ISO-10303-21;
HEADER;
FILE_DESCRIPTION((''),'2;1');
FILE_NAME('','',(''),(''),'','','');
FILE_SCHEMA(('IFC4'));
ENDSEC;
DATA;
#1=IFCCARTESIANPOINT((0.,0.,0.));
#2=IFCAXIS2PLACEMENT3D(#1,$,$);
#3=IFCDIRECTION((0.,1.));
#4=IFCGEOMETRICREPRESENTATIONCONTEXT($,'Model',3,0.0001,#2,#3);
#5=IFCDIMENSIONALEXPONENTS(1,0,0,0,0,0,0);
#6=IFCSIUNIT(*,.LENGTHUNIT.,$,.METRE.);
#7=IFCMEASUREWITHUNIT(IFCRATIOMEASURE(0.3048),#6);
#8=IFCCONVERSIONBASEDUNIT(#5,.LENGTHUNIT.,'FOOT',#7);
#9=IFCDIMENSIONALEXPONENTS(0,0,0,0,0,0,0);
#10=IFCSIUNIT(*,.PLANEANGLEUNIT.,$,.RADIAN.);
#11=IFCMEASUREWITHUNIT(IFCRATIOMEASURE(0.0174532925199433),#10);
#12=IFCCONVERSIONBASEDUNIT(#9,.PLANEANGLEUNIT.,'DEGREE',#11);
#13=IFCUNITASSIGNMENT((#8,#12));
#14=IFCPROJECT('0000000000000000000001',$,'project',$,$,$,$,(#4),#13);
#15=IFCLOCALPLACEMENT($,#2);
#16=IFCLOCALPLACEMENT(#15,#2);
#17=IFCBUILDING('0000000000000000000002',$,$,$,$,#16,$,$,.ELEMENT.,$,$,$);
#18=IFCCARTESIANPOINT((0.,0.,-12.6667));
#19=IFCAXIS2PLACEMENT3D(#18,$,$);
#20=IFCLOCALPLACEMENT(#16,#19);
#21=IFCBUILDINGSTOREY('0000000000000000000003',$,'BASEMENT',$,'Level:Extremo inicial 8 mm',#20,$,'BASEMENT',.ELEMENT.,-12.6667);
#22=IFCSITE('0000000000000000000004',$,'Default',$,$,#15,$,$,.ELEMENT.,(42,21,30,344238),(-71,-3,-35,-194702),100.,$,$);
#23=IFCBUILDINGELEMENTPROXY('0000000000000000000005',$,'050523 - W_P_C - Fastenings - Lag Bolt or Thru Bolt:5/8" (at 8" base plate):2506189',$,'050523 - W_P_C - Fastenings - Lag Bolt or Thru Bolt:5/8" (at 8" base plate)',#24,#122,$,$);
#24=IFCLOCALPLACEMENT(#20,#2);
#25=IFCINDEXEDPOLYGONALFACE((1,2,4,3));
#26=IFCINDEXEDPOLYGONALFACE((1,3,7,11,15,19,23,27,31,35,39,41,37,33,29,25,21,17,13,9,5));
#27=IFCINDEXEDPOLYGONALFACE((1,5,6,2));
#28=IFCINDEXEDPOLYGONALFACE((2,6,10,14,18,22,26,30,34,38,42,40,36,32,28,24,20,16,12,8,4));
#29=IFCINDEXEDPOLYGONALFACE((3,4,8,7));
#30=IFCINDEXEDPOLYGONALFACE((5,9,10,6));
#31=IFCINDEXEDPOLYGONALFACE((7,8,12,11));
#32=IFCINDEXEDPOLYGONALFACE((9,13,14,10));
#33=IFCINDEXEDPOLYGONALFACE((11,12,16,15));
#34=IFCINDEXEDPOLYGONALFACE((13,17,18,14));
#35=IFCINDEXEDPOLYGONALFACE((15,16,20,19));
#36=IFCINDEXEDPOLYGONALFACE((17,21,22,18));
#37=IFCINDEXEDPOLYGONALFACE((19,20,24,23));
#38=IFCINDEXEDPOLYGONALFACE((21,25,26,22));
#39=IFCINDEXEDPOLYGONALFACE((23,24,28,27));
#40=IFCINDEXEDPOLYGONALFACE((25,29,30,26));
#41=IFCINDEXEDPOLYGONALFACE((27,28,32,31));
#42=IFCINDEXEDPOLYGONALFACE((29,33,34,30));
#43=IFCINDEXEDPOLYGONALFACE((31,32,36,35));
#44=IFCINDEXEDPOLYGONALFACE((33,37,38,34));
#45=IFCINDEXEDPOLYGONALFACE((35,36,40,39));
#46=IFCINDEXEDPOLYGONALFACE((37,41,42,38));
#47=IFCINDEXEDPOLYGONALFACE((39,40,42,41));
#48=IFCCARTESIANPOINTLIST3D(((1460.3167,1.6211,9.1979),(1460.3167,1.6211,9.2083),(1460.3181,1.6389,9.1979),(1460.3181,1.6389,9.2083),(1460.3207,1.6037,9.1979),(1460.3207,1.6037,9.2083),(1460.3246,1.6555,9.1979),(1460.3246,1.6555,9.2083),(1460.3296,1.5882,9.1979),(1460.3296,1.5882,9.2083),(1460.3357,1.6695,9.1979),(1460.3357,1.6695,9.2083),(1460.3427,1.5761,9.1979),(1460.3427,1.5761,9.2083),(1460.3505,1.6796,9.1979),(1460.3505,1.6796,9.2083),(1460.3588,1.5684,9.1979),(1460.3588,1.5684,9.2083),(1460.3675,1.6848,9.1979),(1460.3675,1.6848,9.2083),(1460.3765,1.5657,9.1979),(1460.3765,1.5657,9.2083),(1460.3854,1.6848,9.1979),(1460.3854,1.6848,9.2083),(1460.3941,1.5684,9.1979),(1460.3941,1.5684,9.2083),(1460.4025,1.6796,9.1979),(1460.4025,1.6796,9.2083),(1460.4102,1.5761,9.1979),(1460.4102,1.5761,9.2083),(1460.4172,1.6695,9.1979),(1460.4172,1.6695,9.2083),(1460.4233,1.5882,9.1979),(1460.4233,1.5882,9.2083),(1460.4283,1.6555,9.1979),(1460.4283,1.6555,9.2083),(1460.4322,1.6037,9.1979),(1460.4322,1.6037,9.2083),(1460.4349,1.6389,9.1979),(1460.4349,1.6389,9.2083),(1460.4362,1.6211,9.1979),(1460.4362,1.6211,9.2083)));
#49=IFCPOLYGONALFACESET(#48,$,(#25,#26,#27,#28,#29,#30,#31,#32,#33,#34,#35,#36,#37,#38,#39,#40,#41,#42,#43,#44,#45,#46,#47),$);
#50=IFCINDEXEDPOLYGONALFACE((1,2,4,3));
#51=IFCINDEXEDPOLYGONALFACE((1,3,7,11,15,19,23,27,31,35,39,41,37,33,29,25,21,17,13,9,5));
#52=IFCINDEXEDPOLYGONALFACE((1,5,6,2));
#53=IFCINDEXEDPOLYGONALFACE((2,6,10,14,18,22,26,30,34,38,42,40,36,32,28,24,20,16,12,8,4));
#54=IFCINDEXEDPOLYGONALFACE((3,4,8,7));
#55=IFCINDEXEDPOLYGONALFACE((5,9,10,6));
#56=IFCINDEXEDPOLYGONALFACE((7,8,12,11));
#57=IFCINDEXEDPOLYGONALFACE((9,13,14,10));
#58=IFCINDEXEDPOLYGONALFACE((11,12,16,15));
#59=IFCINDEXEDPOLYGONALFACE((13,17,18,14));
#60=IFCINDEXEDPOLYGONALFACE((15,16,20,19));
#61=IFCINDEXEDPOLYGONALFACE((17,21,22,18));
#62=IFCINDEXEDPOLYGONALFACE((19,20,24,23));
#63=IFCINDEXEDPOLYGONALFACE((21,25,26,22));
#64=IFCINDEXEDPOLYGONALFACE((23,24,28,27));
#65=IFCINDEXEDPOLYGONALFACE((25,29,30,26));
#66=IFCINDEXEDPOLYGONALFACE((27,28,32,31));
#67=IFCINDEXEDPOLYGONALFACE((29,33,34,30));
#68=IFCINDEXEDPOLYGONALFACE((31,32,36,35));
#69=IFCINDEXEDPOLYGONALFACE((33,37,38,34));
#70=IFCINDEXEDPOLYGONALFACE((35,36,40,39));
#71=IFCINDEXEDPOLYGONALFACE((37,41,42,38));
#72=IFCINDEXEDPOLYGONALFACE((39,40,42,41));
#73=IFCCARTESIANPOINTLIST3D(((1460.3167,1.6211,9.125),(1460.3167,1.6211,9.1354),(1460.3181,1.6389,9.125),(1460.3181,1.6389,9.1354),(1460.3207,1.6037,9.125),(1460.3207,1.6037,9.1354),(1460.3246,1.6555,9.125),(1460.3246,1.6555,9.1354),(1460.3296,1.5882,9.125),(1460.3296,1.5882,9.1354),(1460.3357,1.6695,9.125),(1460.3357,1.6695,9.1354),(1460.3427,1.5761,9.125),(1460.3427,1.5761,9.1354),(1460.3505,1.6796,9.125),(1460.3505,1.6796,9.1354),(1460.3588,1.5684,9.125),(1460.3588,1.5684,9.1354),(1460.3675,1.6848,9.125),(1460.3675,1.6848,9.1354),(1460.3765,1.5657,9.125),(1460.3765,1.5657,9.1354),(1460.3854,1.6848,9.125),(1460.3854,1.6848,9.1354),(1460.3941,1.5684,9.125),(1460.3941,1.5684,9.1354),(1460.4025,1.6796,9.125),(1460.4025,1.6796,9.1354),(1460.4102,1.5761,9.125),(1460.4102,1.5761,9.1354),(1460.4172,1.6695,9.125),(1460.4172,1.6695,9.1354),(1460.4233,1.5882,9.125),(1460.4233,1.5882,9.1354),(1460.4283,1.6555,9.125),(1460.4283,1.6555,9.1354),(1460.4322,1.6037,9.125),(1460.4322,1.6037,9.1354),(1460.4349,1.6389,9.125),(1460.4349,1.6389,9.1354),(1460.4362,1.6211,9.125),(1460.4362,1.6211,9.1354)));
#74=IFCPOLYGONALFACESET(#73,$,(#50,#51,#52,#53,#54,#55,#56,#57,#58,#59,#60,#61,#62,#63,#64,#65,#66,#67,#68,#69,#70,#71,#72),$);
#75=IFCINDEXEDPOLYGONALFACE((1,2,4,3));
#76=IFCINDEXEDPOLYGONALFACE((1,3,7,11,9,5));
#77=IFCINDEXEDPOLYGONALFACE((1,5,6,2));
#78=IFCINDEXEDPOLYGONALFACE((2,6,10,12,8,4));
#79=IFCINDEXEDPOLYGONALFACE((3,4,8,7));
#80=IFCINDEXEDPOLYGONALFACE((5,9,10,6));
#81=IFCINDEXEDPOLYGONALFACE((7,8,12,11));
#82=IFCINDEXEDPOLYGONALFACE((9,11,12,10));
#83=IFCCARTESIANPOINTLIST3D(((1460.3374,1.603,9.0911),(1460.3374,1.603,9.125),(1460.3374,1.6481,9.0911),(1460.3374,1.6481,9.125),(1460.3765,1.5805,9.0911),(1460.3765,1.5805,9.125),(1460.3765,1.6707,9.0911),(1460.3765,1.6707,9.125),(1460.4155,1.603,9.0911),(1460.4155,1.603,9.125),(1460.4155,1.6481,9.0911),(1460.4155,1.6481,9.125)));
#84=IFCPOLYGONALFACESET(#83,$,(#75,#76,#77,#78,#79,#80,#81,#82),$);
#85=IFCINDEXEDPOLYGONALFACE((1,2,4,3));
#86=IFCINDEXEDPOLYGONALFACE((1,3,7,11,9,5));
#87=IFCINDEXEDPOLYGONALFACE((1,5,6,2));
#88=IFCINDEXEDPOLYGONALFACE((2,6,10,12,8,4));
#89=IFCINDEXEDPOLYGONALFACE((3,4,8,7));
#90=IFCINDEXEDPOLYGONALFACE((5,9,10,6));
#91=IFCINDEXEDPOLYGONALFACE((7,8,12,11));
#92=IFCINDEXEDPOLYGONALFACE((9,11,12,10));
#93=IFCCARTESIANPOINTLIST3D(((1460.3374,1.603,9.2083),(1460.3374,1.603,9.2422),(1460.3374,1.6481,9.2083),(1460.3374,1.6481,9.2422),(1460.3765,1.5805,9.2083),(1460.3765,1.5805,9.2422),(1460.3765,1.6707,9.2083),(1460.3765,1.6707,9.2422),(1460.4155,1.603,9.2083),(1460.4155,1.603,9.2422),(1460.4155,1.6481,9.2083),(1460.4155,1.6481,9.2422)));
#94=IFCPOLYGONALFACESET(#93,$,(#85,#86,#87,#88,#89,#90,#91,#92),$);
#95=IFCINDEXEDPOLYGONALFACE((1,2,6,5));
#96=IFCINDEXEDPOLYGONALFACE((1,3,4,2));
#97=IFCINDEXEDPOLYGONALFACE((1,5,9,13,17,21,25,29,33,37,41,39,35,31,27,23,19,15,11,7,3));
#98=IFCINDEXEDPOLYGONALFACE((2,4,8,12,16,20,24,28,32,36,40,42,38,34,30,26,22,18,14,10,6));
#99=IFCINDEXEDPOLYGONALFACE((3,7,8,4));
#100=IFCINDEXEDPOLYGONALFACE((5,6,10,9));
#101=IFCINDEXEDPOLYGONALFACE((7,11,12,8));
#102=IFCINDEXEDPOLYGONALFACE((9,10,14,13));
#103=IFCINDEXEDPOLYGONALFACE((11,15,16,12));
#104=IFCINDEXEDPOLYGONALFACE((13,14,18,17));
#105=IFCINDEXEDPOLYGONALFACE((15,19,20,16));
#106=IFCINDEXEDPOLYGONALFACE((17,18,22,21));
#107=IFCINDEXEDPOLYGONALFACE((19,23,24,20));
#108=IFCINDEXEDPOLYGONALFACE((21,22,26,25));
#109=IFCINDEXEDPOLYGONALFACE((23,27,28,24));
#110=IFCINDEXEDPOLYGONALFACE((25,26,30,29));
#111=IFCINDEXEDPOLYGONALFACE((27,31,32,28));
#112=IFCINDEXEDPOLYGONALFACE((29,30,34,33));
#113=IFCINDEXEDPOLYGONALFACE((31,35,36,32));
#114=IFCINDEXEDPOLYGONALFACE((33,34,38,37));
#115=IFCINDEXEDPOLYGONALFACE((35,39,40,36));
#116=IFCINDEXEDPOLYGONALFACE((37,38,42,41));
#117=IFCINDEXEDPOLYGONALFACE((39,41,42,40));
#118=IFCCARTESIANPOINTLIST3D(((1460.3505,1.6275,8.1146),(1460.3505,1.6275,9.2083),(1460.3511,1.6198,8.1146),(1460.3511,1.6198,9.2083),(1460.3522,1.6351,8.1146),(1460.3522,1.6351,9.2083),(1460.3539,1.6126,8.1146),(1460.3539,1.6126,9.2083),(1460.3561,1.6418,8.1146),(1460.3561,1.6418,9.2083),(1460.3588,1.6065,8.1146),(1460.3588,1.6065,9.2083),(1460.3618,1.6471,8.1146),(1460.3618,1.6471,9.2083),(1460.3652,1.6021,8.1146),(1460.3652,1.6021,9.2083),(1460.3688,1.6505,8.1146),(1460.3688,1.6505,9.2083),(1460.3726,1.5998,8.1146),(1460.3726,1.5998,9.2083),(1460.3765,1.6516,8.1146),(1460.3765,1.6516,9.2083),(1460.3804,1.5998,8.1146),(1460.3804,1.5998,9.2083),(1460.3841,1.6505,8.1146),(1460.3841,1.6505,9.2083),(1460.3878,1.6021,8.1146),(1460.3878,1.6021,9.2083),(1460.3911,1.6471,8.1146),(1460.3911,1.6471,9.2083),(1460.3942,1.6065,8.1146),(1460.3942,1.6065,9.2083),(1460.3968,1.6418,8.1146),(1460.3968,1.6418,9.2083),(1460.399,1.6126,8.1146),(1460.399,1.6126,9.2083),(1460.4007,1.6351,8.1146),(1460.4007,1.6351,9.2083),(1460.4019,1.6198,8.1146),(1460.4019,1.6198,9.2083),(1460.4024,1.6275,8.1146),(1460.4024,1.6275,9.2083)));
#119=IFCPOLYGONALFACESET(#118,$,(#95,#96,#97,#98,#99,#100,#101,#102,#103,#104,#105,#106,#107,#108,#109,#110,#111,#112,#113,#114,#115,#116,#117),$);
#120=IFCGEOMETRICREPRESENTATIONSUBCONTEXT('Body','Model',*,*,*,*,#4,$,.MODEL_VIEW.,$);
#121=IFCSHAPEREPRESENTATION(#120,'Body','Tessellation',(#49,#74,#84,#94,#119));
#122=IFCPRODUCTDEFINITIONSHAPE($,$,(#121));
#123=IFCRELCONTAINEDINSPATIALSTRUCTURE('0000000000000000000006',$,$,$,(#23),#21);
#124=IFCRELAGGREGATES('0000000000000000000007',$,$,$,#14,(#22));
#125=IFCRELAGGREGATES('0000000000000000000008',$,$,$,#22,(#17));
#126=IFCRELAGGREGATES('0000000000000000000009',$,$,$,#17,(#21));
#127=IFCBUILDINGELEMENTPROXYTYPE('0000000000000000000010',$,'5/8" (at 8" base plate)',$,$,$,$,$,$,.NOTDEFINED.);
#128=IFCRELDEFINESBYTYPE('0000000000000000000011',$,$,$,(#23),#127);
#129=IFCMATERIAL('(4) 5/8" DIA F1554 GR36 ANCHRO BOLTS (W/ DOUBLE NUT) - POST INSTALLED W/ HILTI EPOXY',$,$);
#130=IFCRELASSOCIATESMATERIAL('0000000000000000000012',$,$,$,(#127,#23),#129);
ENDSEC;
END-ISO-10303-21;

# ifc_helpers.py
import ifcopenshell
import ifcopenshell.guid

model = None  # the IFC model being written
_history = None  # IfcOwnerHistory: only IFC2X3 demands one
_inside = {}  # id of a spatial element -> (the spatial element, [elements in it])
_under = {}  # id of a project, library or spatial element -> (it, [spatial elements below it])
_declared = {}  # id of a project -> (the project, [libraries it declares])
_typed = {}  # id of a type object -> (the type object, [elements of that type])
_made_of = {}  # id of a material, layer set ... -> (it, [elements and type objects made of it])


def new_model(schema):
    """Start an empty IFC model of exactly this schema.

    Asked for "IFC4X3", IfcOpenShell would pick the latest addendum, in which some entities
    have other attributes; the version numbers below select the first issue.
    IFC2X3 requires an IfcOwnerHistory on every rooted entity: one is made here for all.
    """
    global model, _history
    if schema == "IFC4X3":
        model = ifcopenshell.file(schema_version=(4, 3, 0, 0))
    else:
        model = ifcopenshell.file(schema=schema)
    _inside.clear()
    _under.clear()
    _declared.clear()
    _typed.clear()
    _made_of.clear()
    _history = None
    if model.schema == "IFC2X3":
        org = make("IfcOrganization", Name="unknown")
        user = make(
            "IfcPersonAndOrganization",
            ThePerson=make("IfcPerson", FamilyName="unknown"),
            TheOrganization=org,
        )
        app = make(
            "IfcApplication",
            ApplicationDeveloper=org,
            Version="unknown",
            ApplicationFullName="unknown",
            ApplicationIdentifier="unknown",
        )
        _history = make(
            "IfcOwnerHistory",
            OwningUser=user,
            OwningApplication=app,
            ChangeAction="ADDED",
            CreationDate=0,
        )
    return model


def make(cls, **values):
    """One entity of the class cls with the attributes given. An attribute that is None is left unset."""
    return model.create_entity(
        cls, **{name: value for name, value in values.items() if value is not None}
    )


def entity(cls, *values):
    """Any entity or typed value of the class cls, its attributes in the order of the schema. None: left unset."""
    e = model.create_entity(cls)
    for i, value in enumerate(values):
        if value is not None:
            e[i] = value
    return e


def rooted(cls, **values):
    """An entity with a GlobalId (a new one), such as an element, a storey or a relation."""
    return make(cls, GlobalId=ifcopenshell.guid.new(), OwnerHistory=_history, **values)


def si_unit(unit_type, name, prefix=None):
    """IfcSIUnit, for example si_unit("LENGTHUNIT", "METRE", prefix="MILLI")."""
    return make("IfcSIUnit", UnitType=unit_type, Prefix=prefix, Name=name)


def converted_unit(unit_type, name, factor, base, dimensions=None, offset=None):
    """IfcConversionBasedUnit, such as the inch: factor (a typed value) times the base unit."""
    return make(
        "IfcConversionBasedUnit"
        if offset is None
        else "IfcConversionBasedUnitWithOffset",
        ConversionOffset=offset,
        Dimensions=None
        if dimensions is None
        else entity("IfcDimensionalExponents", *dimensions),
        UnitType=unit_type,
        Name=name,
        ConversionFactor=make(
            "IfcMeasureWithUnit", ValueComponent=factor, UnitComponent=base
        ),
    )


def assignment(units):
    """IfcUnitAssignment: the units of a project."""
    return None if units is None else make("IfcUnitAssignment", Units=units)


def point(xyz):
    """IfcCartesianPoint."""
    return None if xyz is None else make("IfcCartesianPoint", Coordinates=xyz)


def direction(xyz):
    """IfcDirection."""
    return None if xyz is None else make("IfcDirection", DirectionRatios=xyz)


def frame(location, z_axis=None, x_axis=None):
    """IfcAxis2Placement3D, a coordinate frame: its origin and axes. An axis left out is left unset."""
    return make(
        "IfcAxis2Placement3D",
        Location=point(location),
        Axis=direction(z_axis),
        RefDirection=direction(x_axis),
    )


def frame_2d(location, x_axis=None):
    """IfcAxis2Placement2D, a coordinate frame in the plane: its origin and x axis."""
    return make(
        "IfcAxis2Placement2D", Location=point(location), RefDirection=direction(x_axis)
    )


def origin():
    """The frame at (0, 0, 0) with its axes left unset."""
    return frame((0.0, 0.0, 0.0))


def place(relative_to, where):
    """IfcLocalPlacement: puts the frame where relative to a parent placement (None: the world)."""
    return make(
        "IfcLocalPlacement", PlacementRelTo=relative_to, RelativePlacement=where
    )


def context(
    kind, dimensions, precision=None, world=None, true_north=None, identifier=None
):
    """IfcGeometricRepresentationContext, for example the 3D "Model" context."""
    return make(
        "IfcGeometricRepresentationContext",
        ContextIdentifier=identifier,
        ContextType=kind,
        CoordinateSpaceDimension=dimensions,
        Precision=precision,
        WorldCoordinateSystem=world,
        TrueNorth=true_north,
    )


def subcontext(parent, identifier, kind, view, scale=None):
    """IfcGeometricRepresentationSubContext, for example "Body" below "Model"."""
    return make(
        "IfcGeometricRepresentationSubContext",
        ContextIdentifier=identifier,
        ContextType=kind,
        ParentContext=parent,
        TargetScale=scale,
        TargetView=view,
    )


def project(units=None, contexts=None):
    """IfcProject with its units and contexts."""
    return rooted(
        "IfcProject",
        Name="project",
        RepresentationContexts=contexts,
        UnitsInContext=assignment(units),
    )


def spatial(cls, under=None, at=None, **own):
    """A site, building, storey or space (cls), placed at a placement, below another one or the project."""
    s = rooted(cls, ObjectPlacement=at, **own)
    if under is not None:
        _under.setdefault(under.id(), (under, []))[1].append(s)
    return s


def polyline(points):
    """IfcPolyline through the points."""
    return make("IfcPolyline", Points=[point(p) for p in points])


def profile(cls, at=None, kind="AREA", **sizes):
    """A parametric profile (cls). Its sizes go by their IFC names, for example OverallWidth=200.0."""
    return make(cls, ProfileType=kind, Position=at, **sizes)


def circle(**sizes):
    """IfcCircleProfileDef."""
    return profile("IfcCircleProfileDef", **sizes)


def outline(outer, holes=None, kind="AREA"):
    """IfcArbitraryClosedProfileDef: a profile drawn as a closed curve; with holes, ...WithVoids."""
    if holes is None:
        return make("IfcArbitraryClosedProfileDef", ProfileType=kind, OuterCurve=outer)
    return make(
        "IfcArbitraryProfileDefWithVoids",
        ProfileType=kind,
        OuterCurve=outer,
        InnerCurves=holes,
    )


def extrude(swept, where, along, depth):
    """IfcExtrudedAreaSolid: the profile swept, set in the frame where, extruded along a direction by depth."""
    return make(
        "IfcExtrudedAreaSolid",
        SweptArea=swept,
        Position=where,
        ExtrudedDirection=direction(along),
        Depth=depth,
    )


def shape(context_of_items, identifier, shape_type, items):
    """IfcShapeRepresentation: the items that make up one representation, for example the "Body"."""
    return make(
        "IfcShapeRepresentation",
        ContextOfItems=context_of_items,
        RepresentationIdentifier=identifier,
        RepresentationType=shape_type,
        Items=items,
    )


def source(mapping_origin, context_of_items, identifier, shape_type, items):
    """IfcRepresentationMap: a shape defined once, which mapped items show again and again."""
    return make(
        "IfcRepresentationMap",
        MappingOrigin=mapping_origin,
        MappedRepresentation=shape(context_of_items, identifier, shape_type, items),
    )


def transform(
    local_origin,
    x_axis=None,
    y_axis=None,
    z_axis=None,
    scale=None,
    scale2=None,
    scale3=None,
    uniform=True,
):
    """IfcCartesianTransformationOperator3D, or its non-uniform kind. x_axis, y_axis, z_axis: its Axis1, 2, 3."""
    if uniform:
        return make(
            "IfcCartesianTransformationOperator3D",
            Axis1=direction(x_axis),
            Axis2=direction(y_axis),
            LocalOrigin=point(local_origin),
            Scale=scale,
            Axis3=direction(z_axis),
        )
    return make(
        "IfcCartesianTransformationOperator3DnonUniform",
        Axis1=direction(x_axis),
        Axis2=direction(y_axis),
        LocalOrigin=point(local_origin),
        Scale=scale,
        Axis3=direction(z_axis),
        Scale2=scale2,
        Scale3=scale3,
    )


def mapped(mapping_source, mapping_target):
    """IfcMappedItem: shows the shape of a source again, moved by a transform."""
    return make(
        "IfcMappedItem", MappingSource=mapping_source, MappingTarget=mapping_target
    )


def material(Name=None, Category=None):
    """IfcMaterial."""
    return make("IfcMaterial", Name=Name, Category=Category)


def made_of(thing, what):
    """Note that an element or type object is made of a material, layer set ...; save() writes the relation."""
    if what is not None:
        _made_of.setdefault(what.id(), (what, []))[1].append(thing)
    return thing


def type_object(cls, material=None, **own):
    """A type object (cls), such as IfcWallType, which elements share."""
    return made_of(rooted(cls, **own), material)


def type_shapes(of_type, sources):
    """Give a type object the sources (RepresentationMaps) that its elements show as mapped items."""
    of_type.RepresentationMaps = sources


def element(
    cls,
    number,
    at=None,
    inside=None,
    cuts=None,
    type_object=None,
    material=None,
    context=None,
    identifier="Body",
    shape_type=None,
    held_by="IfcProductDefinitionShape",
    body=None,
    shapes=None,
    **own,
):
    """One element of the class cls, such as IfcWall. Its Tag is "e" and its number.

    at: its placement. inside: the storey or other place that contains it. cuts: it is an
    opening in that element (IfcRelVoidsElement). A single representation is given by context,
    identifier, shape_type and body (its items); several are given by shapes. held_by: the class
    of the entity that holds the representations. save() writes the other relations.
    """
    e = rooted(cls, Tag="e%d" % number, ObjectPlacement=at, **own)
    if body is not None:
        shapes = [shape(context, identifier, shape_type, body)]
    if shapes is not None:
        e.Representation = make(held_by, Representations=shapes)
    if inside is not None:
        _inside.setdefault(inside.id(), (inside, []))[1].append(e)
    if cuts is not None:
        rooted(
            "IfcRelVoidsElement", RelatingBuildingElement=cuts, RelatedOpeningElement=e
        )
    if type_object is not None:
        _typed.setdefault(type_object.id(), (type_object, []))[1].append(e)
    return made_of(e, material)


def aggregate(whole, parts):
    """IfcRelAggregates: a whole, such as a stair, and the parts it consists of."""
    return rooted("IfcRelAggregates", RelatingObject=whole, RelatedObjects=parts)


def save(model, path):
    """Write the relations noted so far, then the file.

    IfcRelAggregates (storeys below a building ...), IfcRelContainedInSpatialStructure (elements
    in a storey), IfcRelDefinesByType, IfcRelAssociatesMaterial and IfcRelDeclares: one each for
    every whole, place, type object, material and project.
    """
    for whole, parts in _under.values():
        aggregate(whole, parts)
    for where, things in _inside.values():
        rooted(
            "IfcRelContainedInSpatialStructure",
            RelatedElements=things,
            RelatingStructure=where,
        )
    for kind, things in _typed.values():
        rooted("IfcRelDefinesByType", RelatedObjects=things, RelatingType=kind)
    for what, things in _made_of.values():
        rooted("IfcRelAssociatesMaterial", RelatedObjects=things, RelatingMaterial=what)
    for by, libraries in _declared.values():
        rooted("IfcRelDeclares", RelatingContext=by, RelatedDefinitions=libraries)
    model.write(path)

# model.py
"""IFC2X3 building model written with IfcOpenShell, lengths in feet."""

from ifc_helpers import new_model, entity, si_unit, converted_unit, direction, frame, frame_2d, origin, place, context, subcontext, project, spatial, polyline, circle, outline, extrude, source, transform, mapped, material, type_object, type_shapes, element, save


model = new_model("IFC2X3")

# Units and contexts
model_context = context("Model", 3, precision=0.0001, world=origin(), true_north=direction((0.0, 1.0)))
body_context = subcontext(model_context, "Body", "Model", "MODEL_VIEW")
ifc_project = project(units=[converted_unit("LENGTHUNIT", "FOOT", entity("IfcRatioMeasure", 0.3048), si_unit("LENGTHUNIT", "METRE"), dimensions=[1, 0, 0, 0, 0, 0, 0]), converted_unit("PLANEANGLEUNIT", "DEGREE", entity("IfcRatioMeasure", 0.0174532925199433), si_unit("PLANEANGLEUNIT", "RADIAN"), dimensions=[0, 0, 0, 0, 0, 0, 0])], contexts=[model_context])

# Site, building, storey
site_placement = place(None, origin())
site = spatial("IfcSite", under=ifc_project, at=site_placement, Name="Default", CompositionType="ELEMENT", RefLatitude=(42, 21, 30, 344238), RefLongitude=(-71, -3, -35, -194702), RefElevation=100.0)
building_placement = place(site_placement, origin())
building = spatial("IfcBuilding", under=site, at=building_placement, CompositionType="ELEMENT")
storey_placement = place(building_placement, frame((0.0, 0.0, -12.6667)))
storey = spatial("IfcBuildingStorey", under=building, at=storey_placement, Name="BASEMENT", ObjectType="Level:Extremo inicial 8 mm", LongName="BASEMENT", CompositionType="ELEMENT", Elevation=-12.6667)

# Building element proxy
ifc_material_1 = material(Name="(4) 5/8\" DIA F1554 GR36 ANCHRO BOLTS (W/ DOUBLE NUT) - POST INSTALLED W/ HILTI EPOXY")
building_element_proxy_type_1 = type_object("IfcBuildingElementProxyType", Name="5/8\" (at 8\" base plate)", PredefinedType="NOTDEFINED", material=ifc_material_1)
shared_shape_1 = source(origin(), body_context, "Body", "SweptSolid", [
    extrude(circle(Radius=0.0599, at=frame_2d((0.0, 0.0), x_axis=(1.0, 0.0))), frame((0.0, 0.0, 0.0), z_axis=(0.0, 0.0, 1.0), x_axis=(0.0, 1.0, 0.0)), (0.0, 0.0, 1.0), 0.0104),
    extrude(circle(Radius=0.0599, at=frame_2d((0.0, 0.0), x_axis=(1.0, 0.0))), frame((0.0, 0.0, -0.0729), z_axis=(0.0, 0.0, 1.0), x_axis=(0.0, 1.0, 0.0)), (0.0, 0.0, 1.0), 0.0104),
    extrude(outline(polyline([(-0.0226, -0.0391), (0.0226, -0.0391), (0.0451, 0.0), (0.0226, 0.0391), (-0.0226, 0.0391), (-0.0451, 0.0), (-0.0226, -0.0391)])), frame((0.0, 0.0, -0.1068), z_axis=(0.0, 0.0, 1.0), x_axis=(0.0, -1.0, 0.0)), (0.0, 0.0, 1.0), 0.0339),
    extrude(outline(polyline([(-0.0226, -0.0391), (0.0226, -0.0391), (0.0451, 0.0), (0.0226, 0.0391), (-0.0226, 0.0391), (-0.0451, 0.0), (-0.0226, -0.0391)])), frame((0.0, 0.0, 0.0104), z_axis=(0.0, 0.0, 1.0), x_axis=(0.866025, -0.5, 0.0)), (0.0, 0.0, 1.0), 0.0339),
    extrude(circle(Radius=0.026, at=frame_2d((0.0, 0.0), x_axis=(1.0, 0.0))), frame((0.0, 0.0, -1.0833), z_axis=(0.0, 0.0, 1.0), x_axis=(0.0, -1.0, 0.0)), (0.0, 0.0, 1.0), 1.0938),
])
type_shapes(building_element_proxy_type_1, [shared_shape_1])
proxy_placement = place(storey_placement, frame((1460.3765, 1.6256, 9.1979), z_axis=(0.0, 0.0, 1.0), x_axis=(-1.0, 0.0, 0.0)))
element("IfcBuildingElementProxy", 1, at=proxy_placement, inside=storey, type_object=building_element_proxy_type_1, material=ifc_material_1, Name="050523 - W_P_C - Fastenings - Lag Bolt or Thru Bolt:5/8\" (at 8\" base plate):2506189", ObjectType="050523 - W_P_C - Fastenings - Lag Bolt or Thru Bolt:5/8\" (at 8\" base plate)", context=body_context, shape_type="MappedRepresentation", body=[
    mapped(shared_shape_1, transform((0.0, 0.0, 0.0), scale=1.0)),
])

save(model, "model.ifc")
